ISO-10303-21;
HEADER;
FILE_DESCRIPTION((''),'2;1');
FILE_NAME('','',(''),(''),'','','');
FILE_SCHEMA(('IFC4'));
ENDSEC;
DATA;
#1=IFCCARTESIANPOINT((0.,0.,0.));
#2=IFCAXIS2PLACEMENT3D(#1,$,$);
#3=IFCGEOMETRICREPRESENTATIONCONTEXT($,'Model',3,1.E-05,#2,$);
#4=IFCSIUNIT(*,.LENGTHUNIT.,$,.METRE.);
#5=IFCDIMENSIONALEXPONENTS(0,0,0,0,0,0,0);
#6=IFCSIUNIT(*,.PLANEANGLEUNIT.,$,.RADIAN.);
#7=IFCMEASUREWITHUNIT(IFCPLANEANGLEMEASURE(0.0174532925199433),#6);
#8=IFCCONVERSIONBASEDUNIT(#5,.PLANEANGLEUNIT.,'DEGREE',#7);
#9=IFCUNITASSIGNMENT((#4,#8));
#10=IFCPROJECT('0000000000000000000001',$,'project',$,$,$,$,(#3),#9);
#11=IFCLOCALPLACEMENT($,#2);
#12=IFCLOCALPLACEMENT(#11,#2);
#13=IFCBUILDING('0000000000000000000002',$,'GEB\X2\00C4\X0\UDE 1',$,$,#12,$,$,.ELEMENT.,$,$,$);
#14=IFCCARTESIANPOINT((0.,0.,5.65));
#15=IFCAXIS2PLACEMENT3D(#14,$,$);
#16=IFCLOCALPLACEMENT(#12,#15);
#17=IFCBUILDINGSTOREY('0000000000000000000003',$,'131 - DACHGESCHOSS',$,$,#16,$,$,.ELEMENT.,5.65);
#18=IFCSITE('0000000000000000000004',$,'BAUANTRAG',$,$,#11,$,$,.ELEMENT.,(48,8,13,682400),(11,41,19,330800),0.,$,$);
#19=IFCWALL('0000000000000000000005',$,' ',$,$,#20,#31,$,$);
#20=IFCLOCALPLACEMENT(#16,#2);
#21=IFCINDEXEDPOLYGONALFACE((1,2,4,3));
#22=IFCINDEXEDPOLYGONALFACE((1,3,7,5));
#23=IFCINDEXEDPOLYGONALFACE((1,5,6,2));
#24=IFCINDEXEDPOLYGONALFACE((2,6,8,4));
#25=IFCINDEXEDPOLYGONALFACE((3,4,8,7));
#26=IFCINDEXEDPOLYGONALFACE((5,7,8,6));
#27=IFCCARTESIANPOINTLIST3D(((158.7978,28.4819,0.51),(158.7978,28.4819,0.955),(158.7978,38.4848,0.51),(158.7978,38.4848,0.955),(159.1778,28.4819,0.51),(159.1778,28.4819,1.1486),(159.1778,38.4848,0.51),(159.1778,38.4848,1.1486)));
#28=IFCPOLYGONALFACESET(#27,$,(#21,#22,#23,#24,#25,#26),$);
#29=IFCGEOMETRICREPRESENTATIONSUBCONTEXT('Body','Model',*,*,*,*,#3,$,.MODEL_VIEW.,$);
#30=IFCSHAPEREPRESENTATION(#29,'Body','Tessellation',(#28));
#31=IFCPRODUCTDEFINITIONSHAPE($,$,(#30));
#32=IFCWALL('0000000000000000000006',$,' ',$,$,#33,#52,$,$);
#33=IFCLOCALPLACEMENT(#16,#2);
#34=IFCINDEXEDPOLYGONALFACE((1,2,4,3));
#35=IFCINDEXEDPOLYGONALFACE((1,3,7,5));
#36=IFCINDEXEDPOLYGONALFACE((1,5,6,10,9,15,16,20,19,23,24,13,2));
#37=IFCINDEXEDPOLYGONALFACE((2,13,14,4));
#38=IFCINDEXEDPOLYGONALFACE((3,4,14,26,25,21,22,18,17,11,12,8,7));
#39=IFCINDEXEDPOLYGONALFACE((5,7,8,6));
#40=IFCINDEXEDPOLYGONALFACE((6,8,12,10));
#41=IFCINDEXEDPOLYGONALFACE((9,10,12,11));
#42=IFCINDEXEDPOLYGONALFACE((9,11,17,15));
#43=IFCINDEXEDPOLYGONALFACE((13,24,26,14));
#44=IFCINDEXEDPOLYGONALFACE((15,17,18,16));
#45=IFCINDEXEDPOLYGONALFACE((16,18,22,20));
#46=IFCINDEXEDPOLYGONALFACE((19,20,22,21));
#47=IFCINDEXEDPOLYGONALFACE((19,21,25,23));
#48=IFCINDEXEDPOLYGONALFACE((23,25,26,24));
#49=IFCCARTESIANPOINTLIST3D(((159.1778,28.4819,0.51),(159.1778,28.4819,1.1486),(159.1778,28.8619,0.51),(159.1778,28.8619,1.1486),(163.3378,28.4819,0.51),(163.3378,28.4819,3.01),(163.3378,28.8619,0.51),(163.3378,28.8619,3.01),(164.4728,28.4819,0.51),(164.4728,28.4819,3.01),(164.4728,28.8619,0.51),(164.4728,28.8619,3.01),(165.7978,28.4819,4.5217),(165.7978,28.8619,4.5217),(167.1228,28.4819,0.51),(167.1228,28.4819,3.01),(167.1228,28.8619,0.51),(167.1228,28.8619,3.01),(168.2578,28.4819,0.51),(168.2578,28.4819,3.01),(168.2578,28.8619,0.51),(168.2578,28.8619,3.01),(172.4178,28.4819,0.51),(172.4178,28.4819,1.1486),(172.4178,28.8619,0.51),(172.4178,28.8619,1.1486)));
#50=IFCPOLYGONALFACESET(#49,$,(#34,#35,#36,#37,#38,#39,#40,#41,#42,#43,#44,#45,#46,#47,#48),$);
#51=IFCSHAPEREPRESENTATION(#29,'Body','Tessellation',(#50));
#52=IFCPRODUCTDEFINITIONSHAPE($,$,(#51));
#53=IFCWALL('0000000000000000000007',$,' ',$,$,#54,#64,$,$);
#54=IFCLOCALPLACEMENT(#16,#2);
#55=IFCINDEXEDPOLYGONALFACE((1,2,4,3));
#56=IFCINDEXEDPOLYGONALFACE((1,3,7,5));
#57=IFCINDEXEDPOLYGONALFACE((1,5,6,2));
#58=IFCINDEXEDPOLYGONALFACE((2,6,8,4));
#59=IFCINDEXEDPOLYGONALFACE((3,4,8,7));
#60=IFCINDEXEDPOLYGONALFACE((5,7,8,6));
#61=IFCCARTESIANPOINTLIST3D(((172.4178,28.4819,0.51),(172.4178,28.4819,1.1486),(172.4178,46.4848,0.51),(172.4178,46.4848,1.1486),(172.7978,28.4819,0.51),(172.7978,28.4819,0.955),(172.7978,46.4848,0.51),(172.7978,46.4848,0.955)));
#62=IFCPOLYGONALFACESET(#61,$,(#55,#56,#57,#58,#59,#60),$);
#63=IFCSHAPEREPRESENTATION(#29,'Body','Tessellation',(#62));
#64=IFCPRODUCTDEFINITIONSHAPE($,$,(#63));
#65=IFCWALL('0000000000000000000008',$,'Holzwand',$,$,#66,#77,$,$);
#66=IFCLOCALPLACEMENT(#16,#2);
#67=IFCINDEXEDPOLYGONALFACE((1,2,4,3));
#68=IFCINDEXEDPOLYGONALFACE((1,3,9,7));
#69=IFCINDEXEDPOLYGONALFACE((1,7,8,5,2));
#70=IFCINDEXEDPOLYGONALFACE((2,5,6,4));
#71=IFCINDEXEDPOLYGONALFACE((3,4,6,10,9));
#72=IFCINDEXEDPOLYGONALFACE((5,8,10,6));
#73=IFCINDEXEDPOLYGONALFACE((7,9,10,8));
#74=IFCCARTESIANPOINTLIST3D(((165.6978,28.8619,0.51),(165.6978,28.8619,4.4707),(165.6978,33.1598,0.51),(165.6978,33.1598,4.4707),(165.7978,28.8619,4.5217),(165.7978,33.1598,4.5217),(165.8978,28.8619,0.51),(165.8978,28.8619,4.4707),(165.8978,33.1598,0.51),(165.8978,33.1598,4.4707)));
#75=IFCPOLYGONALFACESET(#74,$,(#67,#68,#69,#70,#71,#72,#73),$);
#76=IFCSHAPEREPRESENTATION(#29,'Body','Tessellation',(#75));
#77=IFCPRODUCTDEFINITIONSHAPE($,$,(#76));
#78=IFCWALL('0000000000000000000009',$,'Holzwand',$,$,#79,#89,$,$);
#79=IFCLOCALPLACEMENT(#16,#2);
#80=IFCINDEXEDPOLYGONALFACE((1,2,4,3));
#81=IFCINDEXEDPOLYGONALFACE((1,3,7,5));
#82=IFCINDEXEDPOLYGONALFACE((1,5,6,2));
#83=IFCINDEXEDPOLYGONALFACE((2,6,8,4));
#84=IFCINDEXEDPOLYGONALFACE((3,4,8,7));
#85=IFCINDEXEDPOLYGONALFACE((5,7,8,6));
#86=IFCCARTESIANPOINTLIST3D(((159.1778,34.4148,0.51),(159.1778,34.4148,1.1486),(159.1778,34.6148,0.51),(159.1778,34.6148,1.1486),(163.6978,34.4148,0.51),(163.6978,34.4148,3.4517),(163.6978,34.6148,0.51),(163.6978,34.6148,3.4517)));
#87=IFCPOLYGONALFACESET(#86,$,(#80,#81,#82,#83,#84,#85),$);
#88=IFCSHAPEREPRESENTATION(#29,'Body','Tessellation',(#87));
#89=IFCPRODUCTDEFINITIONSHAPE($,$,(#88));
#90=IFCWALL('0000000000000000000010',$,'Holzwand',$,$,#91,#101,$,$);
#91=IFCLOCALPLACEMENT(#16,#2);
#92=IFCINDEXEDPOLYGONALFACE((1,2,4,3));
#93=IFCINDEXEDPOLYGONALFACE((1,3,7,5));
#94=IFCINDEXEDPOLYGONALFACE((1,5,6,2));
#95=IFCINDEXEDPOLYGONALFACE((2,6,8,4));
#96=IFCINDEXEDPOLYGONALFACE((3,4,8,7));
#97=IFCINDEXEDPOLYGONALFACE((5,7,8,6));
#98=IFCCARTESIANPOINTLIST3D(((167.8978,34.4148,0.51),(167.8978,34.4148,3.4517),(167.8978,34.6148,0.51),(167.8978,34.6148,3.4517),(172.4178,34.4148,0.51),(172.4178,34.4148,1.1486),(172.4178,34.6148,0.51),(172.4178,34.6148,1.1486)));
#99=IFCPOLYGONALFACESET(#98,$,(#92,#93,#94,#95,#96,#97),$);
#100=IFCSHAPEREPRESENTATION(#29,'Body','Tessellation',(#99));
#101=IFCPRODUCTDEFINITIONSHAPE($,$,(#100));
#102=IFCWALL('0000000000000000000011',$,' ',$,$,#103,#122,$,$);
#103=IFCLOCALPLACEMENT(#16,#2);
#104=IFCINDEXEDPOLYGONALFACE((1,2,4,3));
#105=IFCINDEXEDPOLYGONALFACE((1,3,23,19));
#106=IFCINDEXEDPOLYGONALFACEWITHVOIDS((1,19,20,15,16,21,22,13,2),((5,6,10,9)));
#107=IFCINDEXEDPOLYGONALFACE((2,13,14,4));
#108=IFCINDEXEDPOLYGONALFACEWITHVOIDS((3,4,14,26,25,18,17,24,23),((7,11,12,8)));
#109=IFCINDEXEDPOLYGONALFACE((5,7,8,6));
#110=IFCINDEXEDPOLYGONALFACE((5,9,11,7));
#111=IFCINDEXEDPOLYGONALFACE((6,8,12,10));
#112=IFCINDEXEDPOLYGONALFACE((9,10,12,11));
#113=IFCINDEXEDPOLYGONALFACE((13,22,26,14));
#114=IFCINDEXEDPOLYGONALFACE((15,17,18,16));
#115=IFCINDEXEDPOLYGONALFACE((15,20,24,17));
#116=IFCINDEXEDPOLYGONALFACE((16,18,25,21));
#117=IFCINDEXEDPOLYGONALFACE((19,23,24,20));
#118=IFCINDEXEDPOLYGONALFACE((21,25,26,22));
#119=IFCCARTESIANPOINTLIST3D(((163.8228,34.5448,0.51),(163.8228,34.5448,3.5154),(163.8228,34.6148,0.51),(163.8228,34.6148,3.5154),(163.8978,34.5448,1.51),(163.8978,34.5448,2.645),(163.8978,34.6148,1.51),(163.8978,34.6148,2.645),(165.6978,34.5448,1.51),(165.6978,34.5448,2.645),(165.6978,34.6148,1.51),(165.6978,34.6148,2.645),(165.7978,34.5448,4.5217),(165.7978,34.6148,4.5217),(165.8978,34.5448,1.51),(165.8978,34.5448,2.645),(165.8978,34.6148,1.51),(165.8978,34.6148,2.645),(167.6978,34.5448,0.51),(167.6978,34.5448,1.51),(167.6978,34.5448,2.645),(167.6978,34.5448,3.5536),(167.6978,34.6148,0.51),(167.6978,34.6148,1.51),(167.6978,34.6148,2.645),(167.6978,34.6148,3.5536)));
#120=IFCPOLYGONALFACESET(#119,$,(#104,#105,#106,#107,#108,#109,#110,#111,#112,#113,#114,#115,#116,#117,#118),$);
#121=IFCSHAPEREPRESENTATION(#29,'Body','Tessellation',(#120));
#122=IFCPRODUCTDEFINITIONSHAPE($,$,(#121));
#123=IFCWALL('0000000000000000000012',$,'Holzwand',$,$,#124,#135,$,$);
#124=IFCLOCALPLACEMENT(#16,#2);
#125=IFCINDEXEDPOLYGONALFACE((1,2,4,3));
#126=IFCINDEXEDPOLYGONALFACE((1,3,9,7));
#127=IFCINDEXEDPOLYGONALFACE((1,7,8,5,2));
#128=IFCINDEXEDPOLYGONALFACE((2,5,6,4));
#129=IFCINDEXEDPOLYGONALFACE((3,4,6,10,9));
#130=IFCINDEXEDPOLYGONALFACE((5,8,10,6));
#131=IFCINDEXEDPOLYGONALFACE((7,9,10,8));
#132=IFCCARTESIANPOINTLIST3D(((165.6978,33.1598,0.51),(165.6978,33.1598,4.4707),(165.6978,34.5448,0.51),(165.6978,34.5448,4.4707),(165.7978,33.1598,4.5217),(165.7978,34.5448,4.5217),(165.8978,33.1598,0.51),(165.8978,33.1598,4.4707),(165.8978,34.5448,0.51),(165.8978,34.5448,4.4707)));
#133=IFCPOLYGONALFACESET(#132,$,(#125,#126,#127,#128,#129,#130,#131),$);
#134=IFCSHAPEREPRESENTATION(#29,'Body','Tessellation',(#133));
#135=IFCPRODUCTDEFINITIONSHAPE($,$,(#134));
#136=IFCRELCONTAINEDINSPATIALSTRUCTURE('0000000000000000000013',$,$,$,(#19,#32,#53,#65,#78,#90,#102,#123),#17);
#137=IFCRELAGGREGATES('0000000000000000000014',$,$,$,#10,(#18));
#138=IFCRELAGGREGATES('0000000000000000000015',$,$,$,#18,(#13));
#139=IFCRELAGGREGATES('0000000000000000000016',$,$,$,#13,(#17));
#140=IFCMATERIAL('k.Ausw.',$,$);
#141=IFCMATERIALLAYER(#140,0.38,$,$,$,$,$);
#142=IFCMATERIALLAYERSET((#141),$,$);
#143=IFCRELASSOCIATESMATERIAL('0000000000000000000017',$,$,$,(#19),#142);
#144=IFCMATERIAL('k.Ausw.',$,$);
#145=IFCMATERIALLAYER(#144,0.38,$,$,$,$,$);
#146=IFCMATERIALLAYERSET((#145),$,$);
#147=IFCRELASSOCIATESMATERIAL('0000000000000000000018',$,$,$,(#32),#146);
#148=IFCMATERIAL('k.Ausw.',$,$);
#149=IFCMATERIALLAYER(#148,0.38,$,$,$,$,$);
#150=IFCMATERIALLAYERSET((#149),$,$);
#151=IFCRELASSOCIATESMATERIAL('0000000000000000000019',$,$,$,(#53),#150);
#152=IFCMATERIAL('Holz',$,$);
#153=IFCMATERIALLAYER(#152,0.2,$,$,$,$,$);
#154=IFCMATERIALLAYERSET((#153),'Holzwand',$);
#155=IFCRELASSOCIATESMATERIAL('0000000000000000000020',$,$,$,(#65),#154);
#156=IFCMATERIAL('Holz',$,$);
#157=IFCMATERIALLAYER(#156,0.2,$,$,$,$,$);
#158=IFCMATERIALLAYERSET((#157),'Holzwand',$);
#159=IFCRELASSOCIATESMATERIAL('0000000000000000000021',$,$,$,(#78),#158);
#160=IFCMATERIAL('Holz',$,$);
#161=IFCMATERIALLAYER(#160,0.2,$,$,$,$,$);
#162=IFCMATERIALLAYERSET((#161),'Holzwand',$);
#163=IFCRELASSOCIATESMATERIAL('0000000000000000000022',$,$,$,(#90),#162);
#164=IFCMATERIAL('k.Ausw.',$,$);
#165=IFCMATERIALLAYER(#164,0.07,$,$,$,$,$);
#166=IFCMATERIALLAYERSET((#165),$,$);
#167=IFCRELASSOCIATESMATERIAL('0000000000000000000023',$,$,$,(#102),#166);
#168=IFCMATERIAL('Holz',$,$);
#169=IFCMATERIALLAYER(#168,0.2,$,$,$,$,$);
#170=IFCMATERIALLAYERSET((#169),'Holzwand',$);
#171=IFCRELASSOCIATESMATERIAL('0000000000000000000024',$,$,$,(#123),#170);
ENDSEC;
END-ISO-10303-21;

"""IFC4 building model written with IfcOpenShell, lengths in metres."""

from ifc_helpers import new_model, entity, si_unit, converted_unit, frame, frame_2d, origin, origin_with_axes, place, context, subcontext, project, spatial, polyline, rectangle, outline, extrude, clip, halfspace, bounded_halfspace, material, layer, layer_set, layer_usage, element, save


model = new_model("IFC4")

# Units and contexts
model_context = context("Model", 3, precision=1e-05, world=origin())
body_context = subcontext(model_context, "Body", "Model", "MODEL_VIEW")
ifc_project = project(units=[si_unit("LENGTHUNIT", "METRE"), converted_unit("PLANEANGLEUNIT", "DEGREE", entity("IfcPlaneAngleMeasure", 0.0174532925199433), si_unit("PLANEANGLEUNIT", "RADIAN"), dimensions=[0, 0, 0, 0, 0, 0, 0])], contexts=[model_context])

# Site, building, storey
site_placement = place(None, origin())
site = spatial("IfcSite", under=ifc_project, at=site_placement, Name="BAUANTRAG", CompositionType="ELEMENT", RefLatitude=(48, 8, 13, 682400), RefLongitude=(11, 41, 19, 330800), RefElevation=0.0)
building_placement = place(site_placement, origin())
building = spatial("IfcBuilding", under=site, at=building_placement, Name="GEBÄUDE 1", CompositionType="ELEMENT")
storey_placement = place(building_placement, frame((0.0, 0.0, 5.65)))
storey = spatial("IfcBuildingStorey", under=building, at=storey_placement, Name="131 - DACHGESCHOSS", CompositionType="ELEMENT", Elevation=5.65)

# Wall
ifc_material_1 = material(Name="k.Ausw.")
ifc_layer_1 = layer(ifc_material_1, 0.38)
ifc_layer_set_1 = layer_set([ifc_layer_1])
ifc_layer_usage_1 = layer_usage(ifc_layer_set_1, "AXIS2", "POSITIVE", 0.0)
wall_1_placement = place(storey_placement, frame((158.7978, 38.4848, 0.51), z_axis=(0.0, 0.0, 1.0), x_axis=(0.0, -1.0, 0.0)))
element("IfcWall", 1, at=wall_1_placement, inside=storey, material=ifc_layer_usage_1, Name=" ", context=body_context, shape_type="Clipping", body=[
    clip(extrude(rectangle(XDim=10.0029, YDim=0.38, at=frame_2d((5.0014, 0.19), x_axis=(1.0, 0.0))), origin_with_axes(), (0.0, 0.0, 1.0), 0.6386), halfspace(frame((5.0014, 0.19, 0.5418), z_axis=(0.0, 0.45399, -0.891007), x_axis=(0.0, -0.891007, -0.45399)), True)),
])

# Wall, openings
ifc_material_2 = material(Name="k.Ausw.")
ifc_layer_2 = layer(ifc_material_2, 0.38)
ifc_layer_set_2 = layer_set([ifc_layer_2])
ifc_layer_usage_2 = layer_usage(ifc_layer_set_2, "AXIS2", "POSITIVE", 0.0)
wall_2_placement = place(storey_placement, frame((159.1778, 28.4819, 0.51)))
wall_2 = element("IfcWall", 2, at=wall_2_placement, inside=storey, material=ifc_layer_usage_2, Name=" ", context=body_context, shape_type="Clipping", body=[
    clip(clip(extrude(rectangle(XDim=13.24, YDim=0.38, at=frame_2d((6.62, 0.19), x_axis=(1.0, 0.0))), origin_with_axes(), (0.0, 0.0, 1.0), 4.0117), bounded_halfspace(frame((3.31, 0.19, 2.3251), z_axis=(0.45399, 0.0, -0.891007), x_axis=(0.0, -1.0, 0.0)), True, origin_with_axes(), polyline([(0.0, 0.38), (0.0, 0.0), (6.62, 0.0), (6.62, 0.38), (0.0, 0.38)]))), bounded_halfspace(frame((9.93, 0.19, 2.3251), z_axis=(-0.45399, 0.0, -0.891007), x_axis=(0.891007, 0.0, -0.45399)), True, origin_with_axes(), polyline([(6.62, 0.0), (13.24, 0.0), (13.24, 0.38), (6.62, 0.38), (6.62, 0.0)]))),
])
opening_1_placement = place(wall_2_placement, frame((9.08, 0.38, 0.0), z_axis=(0.0, -1.0, 0.0), x_axis=(0.0, 0.0, 1.0)))
element("IfcOpeningElement", 3, at=opening_1_placement, cuts=wall_2, ObjectType="Opening", context=body_context, shape_type="SweptSolid", body=[
    extrude(outline(polyline([(0.0, 1.135), (2.5, 1.135), (2.5, 0.0), (0.0, 0.0), (0.0, 1.135)])), origin_with_axes(), (0.0, 0.0, 1.0), 0.38),
])
opening_2_placement = place(wall_2_placement, frame((5.295, 0.38, 0.0), z_axis=(0.0, -1.0, 0.0), x_axis=(0.0, 0.0, 1.0)))
element("IfcOpeningElement", 4, at=opening_2_placement, cuts=wall_2, ObjectType="Opening", context=body_context, shape_type="SweptSolid", body=[
    extrude(outline(polyline([(0.0, 1.135), (2.5, 1.135), (2.5, 0.0), (0.0, 0.0), (0.0, 1.135)])), origin_with_axes(), (0.0, 0.0, 1.0), 0.38),
])

# Walls
ifc_material_3 = material(Name="k.Ausw.")
ifc_layer_3 = layer(ifc_material_3, 0.38)
ifc_layer_set_3 = layer_set([ifc_layer_3])
ifc_layer_usage_3 = layer_usage(ifc_layer_set_3, "AXIS2", "POSITIVE", 0.0)
wall_3_placement = place(storey_placement, frame((172.7978, 28.4819, 0.51), z_axis=(0.0, 0.0, 1.0), x_axis=(0.0, 1.0, 0.0)))
element("IfcWall", 5, at=wall_3_placement, inside=storey, material=ifc_layer_usage_3, Name=" ", context=body_context, shape_type="Clipping", body=[
    clip(extrude(rectangle(XDim=18.0029, YDim=0.38, at=frame_2d((9.0014, 0.19), x_axis=(1.0, 0.0))), origin_with_axes(), (0.0, 0.0, 1.0), 0.6386), halfspace(frame((9.0014, 0.19, 0.5418), z_axis=(0.0, 0.45399, -0.891007), x_axis=(0.0, -0.891007, -0.45399)), True)),
])
ifc_material_4 = material(Name="Holz")
ifc_layer_4 = layer(ifc_material_4, 0.2)
ifc_layer_set_4 = layer_set([ifc_layer_4], Name="Holzwand")
ifc_layer_usage_4 = layer_usage(ifc_layer_set_4, "AXIS2", "POSITIVE", 0.0)
wall_4_placement = place(storey_placement, frame((165.6978, 33.1598, 0.51), z_axis=(0.0, 0.0, 1.0), x_axis=(0.0, -1.0, 0.0)))
element("IfcWall", 6, at=wall_4_placement, inside=storey, material=ifc_layer_usage_4, Name="Holzwand", context=body_context, shape_type="Clipping", body=[
    clip(clip(extrude(rectangle(XDim=4.2979, YDim=0.2, at=frame_2d((2.1489, 0.1), x_axis=(1.0, 0.0))), origin_with_axes(), (0.0, 0.0, 1.0), 4.0117), bounded_halfspace(frame((2.1489, 0.05, 3.9862), z_axis=(0.0, 0.45399, -0.891007), x_axis=(0.0, 0.891007, 0.45399)), True, origin_with_axes(), polyline([(4.2979, 0.0), (4.2979, 0.1), (0.0, 0.1), (0.0, 0.0), (4.2979, 0.0)]))), bounded_halfspace(frame((2.1489, 0.15, 3.9862), z_axis=(0.0, -0.45399, -0.891007), x_axis=(0.0, -0.891007, 0.45399)), True, origin_with_axes(), polyline([(0.0, 0.2), (0.0, 0.1), (4.2979, 0.1), (4.2979, 0.2), (0.0, 0.2)]))),
])
ifc_material_5 = material(Name="Holz")
ifc_layer_5 = layer(ifc_material_5, 0.2)
ifc_layer_set_5 = layer_set([ifc_layer_5], Name="Holzwand")
ifc_layer_usage_5 = layer_usage(ifc_layer_set_5, "AXIS2", "POSITIVE", 0.0)
wall_5_placement = place(storey_placement, frame((159.1778, 34.4148, 0.51)))
element("IfcWall", 7, at=wall_5_placement, inside=storey, material=ifc_layer_usage_5, Name="Holzwand", context=body_context, shape_type="Clipping", body=[
    clip(extrude(rectangle(XDim=4.52, YDim=0.2, at=frame_2d((2.26, 0.1), x_axis=(1.0, 0.0))), origin_with_axes(), (0.0, 0.0, 1.0), 2.9417), halfspace(frame((2.26, 0.1, 1.7901), z_axis=(0.45399, 0.0, -0.891007), x_axis=(0.891007, 0.0, 0.45399)), True)),
])
ifc_material_6 = material(Name="Holz")
ifc_layer_6 = layer(ifc_material_6, 0.2)
ifc_layer_set_6 = layer_set([ifc_layer_6], Name="Holzwand")
ifc_layer_usage_6 = layer_usage(ifc_layer_set_6, "AXIS2", "POSITIVE", 0.0)
wall_6_placement = place(storey_placement, frame((167.8978, 34.4148, 0.51)))
element("IfcWall", 8, at=wall_6_placement, inside=storey, material=ifc_layer_usage_6, Name="Holzwand", context=body_context, shape_type="Clipping", body=[
    clip(extrude(rectangle(XDim=4.52, YDim=0.2, at=frame_2d((2.26, 0.1), x_axis=(1.0, 0.0))), origin_with_axes(), (0.0, 0.0, 1.0), 2.9417), halfspace(frame((2.26, 0.1, 1.7901), z_axis=(-0.45399, 0.0, -0.891007), x_axis=(0.891007, 0.0, -0.45399)), True)),
])

# Wall, openings
ifc_material_7 = material(Name="k.Ausw.")
ifc_layer_7 = layer(ifc_material_7, 0.07)
ifc_layer_set_7 = layer_set([ifc_layer_7])
ifc_layer_usage_7 = layer_usage(ifc_layer_set_7, "AXIS2", "POSITIVE", 0.0)
wall_7_placement = place(storey_placement, frame((163.8228, 34.5448, 0.51)))
wall_7 = element("IfcWall", 9, at=wall_7_placement, inside=storey, material=ifc_layer_usage_7, Name=" ", context=body_context, shape_type="Clipping", body=[
    clip(clip(extrude(rectangle(XDim=3.875, YDim=0.07, at=frame_2d((1.9375, 0.035), x_axis=(1.0, 0.0))), origin_with_axes(), (0.0, 0.0, 1.0), 4.0117), bounded_halfspace(frame((0.9875, 0.035, 3.5085), z_axis=(0.45399, 0.0, -0.891007), x_axis=(0.891007, 0.0, 0.45399)), True, origin_with_axes(), polyline([(0.0, 0.0), (1.975, 0.0), (1.975, 0.07), (0.0, 0.07), (0.0, 0.0)]))), bounded_halfspace(frame((2.925, 0.035, 3.5276), z_axis=(-0.45399, 0.0, -0.891007), x_axis=(-0.891007, 0.0, 0.45399)), True, origin_with_axes(), polyline([(3.875, 0.07), (1.975, 0.07), (1.975, 0.0), (3.875, 0.0), (3.875, 0.07)]))),
])
opening_3_placement = place(wall_7_placement, frame((0.075, 0.0, 1.0), z_axis=(0.0, 1.0, 0.0), x_axis=(0.0, 0.0, 1.0)))
element("IfcOpeningElement", 10, at=opening_3_placement, cuts=wall_7, ObjectType="Opening", context=body_context, shape_type="SweptSolid", body=[
    extrude(outline(polyline([(0.0, 1.8), (1.135, 1.8), (1.135, 0.0), (0.0, 0.0), (0.0, 1.8)])), origin_with_axes(), (0.0, 0.0, 1.0), 0.07),
])
opening_4_placement = place(wall_7_placement, frame((2.075, 0.0, 1.0), z_axis=(0.0, 1.0, 0.0), x_axis=(0.0, 0.0, 1.0)))
element("IfcOpeningElement", 11, at=opening_4_placement, cuts=wall_7, ObjectType="Opening", context=body_context, shape_type="SweptSolid", body=[
    extrude(outline(polyline([(0.0, 1.8), (1.135, 1.8), (1.135, 0.0), (0.0, 0.0), (0.0, 1.8)])), origin_with_axes(), (0.0, 0.0, 1.0), 0.07),
])

# Wall
ifc_material_8 = material(Name="Holz")
ifc_layer_8 = layer(ifc_material_8, 0.2)
ifc_layer_set_8 = layer_set([ifc_layer_8], Name="Holzwand")
ifc_layer_usage_8 = layer_usage(ifc_layer_set_8, "AXIS2", "POSITIVE", 0.0)
wall_8_placement = place(storey_placement, frame((165.6978, 34.5448, 0.51), z_axis=(0.0, 0.0, 1.0), x_axis=(0.0, -1.0, 0.0)))
element("IfcWall", 12, at=wall_8_placement, inside=storey, material=ifc_layer_usage_8, Name="Holzwand", context=body_context, shape_type="Clipping", body=[
    clip(clip(extrude(rectangle(XDim=1.385, YDim=0.2, at=frame_2d((0.6925, 0.1), x_axis=(1.0, 0.0))), origin_with_axes(), (0.0, 0.0, 1.0), 4.0117), bounded_halfspace(frame((0.6925, 0.05, 3.9862), z_axis=(0.0, 0.45399, -0.891007), x_axis=(0.0, 0.891007, 0.45399)), True, origin_with_axes(), polyline([(1.385, 0.0), (1.385, 0.1), (0.0, 0.1), (0.0, 0.0), (1.385, 0.0)]))), bounded_halfspace(frame((0.6925, 0.15, 3.9862), z_axis=(0.0, -0.45399, -0.891007), x_axis=(0.0, -0.891007, 0.45399)), True, origin_with_axes(), polyline([(0.0, 0.2), (0.0, 0.1), (1.385, 0.1), (1.385, 0.2), (0.0, 0.2)]))),
])

save(model, "model.ifc")
